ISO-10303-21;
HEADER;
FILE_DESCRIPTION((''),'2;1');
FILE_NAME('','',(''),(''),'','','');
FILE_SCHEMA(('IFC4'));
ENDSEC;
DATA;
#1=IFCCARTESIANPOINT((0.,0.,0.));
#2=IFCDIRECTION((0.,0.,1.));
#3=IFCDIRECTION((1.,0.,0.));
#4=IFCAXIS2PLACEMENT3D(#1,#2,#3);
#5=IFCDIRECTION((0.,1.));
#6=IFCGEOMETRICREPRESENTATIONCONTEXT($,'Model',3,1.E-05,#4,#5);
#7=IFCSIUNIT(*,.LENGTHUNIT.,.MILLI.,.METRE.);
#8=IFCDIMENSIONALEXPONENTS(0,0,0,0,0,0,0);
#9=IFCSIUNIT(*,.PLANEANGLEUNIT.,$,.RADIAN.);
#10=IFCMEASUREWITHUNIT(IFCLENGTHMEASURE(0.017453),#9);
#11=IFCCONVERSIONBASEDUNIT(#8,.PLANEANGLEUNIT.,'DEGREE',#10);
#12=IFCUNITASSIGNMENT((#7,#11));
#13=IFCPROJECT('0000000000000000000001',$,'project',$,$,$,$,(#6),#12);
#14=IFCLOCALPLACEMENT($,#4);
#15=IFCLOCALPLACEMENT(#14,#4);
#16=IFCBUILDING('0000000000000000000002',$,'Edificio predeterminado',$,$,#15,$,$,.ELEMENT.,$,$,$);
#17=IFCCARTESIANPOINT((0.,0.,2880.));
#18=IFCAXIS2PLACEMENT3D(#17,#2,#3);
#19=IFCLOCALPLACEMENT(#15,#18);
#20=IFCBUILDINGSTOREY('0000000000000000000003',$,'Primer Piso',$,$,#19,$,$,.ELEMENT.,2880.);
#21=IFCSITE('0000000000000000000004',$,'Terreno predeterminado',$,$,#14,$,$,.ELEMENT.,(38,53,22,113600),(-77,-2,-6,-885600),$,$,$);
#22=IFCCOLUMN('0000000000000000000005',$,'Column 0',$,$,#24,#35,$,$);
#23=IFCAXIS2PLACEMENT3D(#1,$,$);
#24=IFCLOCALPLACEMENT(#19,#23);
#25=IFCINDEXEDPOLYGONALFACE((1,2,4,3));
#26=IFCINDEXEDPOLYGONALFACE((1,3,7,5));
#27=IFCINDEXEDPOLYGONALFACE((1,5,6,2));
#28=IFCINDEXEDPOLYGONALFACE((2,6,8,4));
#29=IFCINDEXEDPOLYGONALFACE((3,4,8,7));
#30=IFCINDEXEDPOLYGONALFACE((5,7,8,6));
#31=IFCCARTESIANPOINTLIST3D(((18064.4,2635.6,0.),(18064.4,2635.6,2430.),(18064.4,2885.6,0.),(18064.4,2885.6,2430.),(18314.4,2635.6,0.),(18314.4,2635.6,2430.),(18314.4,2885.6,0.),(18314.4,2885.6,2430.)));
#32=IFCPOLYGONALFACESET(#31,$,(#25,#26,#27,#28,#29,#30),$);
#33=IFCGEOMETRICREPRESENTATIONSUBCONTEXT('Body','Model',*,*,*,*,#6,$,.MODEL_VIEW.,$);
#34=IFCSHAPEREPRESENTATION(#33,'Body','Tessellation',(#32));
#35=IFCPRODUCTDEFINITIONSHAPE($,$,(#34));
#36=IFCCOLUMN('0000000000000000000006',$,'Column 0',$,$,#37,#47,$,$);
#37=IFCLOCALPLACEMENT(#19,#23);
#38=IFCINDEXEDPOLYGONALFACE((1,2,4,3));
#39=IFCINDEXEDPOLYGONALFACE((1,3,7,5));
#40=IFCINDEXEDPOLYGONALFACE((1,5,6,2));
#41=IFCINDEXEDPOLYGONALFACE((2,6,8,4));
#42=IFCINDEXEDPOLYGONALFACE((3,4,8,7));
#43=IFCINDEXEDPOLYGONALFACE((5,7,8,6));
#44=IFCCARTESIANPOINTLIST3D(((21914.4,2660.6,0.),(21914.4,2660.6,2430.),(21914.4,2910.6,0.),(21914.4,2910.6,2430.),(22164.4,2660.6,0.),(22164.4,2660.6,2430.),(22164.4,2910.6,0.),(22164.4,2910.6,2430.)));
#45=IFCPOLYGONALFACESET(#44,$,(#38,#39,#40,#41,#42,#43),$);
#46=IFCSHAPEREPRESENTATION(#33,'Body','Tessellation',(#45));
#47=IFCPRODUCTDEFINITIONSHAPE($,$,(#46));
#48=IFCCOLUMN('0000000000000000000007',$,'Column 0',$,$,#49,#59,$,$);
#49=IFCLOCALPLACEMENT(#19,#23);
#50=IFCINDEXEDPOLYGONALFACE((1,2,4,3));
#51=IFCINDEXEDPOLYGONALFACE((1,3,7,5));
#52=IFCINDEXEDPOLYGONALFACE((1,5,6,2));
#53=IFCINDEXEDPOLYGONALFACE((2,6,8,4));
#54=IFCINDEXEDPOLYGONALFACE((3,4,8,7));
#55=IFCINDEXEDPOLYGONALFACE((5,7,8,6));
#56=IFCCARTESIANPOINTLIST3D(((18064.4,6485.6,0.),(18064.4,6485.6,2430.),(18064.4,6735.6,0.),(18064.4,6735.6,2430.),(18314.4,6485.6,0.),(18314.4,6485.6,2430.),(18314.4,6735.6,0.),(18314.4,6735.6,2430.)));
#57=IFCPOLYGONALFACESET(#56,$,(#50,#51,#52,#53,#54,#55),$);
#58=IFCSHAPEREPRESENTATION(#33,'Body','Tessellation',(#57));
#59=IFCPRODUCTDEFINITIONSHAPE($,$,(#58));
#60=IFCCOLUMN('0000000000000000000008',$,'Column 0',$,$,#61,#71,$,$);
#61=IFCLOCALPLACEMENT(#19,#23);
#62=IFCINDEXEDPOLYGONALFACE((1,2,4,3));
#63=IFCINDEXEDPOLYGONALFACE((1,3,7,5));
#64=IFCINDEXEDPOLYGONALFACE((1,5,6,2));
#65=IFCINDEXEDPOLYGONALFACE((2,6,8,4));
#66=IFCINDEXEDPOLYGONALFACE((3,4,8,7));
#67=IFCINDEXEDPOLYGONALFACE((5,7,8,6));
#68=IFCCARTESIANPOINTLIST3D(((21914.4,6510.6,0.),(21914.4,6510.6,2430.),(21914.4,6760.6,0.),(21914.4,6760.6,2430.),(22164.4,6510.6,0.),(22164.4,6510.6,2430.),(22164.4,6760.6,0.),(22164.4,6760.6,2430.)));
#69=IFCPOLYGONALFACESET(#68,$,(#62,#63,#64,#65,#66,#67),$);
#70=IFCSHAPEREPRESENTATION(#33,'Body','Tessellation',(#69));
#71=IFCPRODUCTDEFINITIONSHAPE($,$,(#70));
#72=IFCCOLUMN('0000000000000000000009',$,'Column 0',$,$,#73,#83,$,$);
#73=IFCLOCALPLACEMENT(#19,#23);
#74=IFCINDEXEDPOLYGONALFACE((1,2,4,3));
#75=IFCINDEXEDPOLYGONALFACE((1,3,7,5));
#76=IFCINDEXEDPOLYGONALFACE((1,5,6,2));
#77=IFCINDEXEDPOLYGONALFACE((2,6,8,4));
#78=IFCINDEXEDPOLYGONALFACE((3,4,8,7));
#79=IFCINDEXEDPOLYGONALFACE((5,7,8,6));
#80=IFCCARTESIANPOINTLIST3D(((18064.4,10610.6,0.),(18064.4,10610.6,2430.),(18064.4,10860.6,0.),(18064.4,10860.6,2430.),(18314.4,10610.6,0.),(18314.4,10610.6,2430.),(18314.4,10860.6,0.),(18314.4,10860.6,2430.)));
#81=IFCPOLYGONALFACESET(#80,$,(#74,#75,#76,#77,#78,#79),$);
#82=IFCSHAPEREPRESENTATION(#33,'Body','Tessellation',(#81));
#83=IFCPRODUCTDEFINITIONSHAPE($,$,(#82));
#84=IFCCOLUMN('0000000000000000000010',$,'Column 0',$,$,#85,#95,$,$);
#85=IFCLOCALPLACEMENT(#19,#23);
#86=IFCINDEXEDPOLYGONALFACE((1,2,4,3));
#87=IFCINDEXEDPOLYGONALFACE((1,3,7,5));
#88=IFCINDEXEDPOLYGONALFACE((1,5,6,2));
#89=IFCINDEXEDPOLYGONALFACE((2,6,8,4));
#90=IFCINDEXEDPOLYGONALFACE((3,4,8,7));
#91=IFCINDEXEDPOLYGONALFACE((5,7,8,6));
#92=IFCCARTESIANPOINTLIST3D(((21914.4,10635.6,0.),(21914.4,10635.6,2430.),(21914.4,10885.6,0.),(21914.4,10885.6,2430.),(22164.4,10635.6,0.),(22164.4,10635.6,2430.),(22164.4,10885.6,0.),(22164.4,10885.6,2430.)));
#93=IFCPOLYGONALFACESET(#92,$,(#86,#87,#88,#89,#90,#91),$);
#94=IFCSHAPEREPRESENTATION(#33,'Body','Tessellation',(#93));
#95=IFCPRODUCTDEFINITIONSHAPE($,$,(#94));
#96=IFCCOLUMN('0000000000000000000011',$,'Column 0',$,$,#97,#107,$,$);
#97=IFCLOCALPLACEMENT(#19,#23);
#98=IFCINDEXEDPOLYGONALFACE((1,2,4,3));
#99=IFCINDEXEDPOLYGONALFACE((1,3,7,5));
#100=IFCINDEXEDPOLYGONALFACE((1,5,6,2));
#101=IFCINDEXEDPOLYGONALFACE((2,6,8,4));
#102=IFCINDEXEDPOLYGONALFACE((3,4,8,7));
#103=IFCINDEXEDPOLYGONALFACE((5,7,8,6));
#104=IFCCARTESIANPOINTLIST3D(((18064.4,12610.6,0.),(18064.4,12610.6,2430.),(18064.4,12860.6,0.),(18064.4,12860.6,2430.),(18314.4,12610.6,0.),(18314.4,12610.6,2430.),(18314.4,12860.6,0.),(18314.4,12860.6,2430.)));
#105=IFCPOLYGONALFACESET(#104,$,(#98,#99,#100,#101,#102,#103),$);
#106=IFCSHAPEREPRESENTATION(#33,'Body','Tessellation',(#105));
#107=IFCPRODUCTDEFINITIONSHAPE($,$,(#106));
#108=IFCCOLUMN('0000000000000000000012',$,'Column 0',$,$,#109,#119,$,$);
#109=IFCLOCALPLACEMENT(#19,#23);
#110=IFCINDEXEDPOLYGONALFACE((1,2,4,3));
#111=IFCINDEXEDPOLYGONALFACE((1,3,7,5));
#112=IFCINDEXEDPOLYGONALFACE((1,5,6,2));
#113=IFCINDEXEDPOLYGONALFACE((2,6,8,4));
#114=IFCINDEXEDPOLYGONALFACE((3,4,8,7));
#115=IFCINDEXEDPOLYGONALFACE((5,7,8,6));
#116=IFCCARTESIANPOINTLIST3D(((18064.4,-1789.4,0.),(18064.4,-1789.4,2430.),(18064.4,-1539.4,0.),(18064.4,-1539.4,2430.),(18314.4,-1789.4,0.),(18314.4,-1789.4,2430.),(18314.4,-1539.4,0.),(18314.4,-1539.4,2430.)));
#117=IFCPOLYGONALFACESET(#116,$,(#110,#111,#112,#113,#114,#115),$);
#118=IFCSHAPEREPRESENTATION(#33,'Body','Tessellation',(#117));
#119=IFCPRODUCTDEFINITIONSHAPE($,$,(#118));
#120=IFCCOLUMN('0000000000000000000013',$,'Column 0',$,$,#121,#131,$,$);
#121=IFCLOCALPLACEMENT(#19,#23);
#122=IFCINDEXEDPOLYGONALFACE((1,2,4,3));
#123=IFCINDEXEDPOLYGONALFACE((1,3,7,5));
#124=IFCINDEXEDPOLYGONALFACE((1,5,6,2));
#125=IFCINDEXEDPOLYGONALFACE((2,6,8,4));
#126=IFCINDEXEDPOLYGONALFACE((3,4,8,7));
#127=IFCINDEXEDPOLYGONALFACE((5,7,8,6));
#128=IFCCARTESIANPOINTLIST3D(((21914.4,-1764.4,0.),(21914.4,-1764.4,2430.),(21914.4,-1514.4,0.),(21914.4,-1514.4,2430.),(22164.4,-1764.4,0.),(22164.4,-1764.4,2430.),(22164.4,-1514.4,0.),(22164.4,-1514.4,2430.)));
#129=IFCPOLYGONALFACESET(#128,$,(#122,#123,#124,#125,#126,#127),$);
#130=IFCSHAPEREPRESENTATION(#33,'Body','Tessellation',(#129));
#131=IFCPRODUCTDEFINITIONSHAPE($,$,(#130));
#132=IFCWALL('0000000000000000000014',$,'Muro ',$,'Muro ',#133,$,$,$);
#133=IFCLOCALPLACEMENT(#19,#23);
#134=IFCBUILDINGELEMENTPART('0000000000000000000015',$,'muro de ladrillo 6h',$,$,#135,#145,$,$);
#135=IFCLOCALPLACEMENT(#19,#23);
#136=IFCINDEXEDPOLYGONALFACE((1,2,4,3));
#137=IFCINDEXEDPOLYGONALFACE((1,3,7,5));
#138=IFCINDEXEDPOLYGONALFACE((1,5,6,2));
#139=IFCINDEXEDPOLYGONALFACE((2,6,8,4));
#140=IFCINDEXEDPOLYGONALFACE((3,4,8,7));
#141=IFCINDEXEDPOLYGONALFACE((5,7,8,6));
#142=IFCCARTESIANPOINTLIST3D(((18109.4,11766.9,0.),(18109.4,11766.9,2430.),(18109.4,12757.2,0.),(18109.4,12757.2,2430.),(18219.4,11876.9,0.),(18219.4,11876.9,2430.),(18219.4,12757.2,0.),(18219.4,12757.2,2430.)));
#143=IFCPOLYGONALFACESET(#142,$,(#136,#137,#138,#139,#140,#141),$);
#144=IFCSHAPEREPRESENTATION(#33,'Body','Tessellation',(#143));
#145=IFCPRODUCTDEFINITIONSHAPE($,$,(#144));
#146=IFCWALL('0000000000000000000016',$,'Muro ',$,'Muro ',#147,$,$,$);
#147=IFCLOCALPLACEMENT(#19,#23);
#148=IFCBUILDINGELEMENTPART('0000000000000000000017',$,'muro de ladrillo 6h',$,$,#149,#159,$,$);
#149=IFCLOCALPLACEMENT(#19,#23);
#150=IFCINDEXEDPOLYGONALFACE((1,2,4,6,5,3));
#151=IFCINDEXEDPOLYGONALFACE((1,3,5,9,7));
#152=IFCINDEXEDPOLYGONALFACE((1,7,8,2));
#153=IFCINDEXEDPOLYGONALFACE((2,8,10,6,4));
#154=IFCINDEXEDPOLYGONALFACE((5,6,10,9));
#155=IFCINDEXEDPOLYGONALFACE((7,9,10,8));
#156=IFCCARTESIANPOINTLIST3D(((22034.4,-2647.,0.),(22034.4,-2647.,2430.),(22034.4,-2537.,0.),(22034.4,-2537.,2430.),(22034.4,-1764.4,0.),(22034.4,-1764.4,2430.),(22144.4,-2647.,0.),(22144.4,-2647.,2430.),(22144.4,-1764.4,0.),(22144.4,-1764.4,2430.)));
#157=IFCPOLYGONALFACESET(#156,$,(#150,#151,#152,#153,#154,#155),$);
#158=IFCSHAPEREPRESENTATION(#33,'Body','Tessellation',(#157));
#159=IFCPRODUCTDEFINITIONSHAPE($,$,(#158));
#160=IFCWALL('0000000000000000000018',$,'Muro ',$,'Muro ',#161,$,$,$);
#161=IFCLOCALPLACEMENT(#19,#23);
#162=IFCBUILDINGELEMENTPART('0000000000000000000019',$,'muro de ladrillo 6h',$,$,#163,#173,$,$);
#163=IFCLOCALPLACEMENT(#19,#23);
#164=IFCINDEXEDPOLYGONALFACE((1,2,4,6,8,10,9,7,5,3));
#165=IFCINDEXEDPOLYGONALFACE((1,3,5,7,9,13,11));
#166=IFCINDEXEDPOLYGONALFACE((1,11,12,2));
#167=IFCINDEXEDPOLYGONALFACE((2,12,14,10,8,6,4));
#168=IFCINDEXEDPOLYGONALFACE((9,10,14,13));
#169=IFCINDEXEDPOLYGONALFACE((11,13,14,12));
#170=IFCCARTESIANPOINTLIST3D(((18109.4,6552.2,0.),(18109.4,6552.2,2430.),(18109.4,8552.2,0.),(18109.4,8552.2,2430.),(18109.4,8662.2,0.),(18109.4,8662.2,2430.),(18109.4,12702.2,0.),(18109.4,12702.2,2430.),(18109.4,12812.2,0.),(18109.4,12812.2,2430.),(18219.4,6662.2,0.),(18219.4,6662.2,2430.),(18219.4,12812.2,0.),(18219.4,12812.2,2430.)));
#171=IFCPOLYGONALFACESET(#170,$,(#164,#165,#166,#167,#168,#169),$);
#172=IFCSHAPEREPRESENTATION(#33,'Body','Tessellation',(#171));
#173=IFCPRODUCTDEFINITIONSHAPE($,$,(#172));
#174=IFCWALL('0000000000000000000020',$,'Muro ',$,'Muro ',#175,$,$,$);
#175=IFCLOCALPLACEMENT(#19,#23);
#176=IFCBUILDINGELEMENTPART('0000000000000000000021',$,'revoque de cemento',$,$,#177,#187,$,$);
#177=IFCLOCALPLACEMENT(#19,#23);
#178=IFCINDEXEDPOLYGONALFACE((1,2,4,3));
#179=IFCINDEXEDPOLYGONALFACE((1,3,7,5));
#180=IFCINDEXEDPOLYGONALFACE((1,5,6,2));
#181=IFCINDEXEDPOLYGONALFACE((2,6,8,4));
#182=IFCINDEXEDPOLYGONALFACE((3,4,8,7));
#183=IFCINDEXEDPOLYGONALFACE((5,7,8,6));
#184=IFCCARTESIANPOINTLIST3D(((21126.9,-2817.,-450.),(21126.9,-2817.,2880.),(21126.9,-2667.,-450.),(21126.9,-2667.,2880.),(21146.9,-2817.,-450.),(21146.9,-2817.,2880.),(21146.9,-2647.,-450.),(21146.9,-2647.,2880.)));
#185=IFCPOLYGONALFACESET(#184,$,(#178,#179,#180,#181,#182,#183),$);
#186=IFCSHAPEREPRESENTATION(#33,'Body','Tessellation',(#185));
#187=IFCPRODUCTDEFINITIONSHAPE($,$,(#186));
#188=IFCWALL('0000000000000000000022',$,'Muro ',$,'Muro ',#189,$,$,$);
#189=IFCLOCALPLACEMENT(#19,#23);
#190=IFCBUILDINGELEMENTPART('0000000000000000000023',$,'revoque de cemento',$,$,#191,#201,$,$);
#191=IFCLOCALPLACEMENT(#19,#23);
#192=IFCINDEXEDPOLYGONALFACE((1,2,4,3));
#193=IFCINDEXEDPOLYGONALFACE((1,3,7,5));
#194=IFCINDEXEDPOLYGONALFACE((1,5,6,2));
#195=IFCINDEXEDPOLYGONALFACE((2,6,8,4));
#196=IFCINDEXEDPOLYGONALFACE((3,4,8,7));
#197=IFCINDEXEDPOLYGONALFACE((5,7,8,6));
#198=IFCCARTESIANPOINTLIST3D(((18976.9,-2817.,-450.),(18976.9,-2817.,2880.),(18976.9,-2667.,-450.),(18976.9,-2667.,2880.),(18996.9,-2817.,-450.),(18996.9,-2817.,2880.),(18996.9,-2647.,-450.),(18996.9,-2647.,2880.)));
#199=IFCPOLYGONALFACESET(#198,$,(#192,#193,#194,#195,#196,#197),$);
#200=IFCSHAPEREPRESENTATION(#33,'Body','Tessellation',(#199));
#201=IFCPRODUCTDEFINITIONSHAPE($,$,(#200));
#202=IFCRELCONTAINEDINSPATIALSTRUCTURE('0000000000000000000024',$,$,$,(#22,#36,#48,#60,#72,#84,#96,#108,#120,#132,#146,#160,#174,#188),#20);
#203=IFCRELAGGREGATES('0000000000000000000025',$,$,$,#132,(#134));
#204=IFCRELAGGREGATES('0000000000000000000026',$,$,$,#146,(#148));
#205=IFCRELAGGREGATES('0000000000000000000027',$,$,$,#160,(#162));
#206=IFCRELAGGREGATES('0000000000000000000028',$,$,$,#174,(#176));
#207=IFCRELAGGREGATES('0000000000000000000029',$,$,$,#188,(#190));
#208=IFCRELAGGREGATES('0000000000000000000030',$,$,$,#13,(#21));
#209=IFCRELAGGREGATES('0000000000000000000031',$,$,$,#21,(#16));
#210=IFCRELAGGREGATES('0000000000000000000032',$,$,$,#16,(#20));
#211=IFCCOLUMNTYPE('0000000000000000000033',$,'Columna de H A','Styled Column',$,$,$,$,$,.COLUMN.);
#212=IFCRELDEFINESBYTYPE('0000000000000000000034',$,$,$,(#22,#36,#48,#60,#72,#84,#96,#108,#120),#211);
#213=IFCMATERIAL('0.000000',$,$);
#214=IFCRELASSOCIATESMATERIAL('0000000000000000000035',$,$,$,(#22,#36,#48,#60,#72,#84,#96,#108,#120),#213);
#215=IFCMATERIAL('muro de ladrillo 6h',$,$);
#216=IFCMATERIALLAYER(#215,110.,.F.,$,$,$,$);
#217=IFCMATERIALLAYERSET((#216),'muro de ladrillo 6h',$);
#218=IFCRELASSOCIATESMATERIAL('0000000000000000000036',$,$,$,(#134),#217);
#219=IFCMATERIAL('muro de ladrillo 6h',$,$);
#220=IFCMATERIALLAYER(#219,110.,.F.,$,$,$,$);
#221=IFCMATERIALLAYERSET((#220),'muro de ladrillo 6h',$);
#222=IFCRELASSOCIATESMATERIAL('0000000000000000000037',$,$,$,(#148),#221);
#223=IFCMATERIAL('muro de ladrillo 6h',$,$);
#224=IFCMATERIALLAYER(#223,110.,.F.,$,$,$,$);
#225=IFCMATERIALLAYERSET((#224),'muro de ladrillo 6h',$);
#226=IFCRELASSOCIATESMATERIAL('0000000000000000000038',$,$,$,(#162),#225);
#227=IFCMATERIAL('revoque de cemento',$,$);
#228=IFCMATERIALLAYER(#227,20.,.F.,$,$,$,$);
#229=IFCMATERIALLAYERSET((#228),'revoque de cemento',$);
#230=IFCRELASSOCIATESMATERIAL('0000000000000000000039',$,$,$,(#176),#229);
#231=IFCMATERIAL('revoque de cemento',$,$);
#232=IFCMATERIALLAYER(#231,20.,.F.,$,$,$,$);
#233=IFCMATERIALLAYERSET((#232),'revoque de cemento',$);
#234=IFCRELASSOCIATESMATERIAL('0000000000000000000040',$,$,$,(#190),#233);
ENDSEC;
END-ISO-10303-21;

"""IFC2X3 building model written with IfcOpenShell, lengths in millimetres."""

from ifc_helpers import new_model, entity, si_unit, converted_unit, direction, frame, origin_with_axes, place, context, subcontext, project, spatial, polyline, outline, extrude, clip, bounded_halfspace, material, layer, layer_set, layer_usage, type_object, element, aggregate, save


model = new_model("IFC2X3")

# Units and contexts
model_context = context("Model", 3, precision=1e-05, world=origin_with_axes(), true_north=direction((0.0, 1.0)))
body_context = subcontext(model_context, "Body", "Model", "MODEL_VIEW")
ifc_project = project(units=[si_unit("LENGTHUNIT", "METRE", prefix="MILLI"), converted_unit("PLANEANGLEUNIT", "DEGREE", entity("IfcLengthMeasure", 0.017453), si_unit("PLANEANGLEUNIT", "RADIAN"), dimensions=[0, 0, 0, 0, 0, 0, 0])], contexts=[model_context])

# Site, building, storey
site_placement = place(None, origin_with_axes())
site = spatial("IfcSite", under=ifc_project, at=site_placement, Name="Terreno predeterminado", CompositionType="ELEMENT", RefLatitude=(38, 53, 22, 113600), RefLongitude=(-77, -2, -6, -885600))
building_placement = place(site_placement, origin_with_axes())
building = spatial("IfcBuilding", under=site, at=building_placement, Name="Edificio predeterminado", CompositionType="ELEMENT")
storey_placement = place(building_placement, frame((0.0, 0.0, 2880.0), z_axis=(0.0, 0.0, 1.0), x_axis=(1.0, 0.0, 0.0)))
storey = spatial("IfcBuildingStorey", under=building, at=storey_placement, Name="Primer Piso", CompositionType="ELEMENT", Elevation=2880.0)

# Columns
ifc_material_1 = material(Name="0.000000")
column_type = type_object("IfcColumnType", Name="Columna de H A", Description="Styled Column", PredefinedType="COLUMN")
for number, where, z_axis, x_axis, name in (
    (1, (18189.4, 2760.6, 0.0), (0.0, 0.0, 1.0), (1.0, 0.0, 0.0), "Column 0"),
    (2, (22039.4, 2785.6, 0.0), (0.0, 0.0, 1.0), (1.0, 0.0, 0.0), "Column 0"),
    (3, (18189.4, 6610.6, 0.0), (0.0, 0.0, 1.0), (1.0, 0.0, 0.0), "Column 0"),
    (4, (22039.4, 6635.6, 0.0), (0.0, 0.0, 1.0), (1.0, 0.0, 0.0), "Column 0"),
    (5, (18189.4, 10735.6, 0.0), (0.0, 0.0, 1.0), (1.0, 0.0, 0.0), "Column 0"),
    (6, (22039.4, 10760.6, 0.0), (0.0, 0.0, 1.0), (1.0, 0.0, 0.0), "Column 0"),
    (7, (18189.4, 12735.6, 0.0), (0.0, 0.0, 1.0), (1.0, 0.0, 0.0), "Column 0"),
    (8, (18189.4, -1664.4, 0.0), (0.0, 0.0, 1.0), (1.0, 0.0, 0.0), "Column 0"),
    (9, (22039.4, -1639.4, 0.0), (0.0, 0.0, 1.0), (1.0, 0.0, 0.0), "Column 0"),
):
    element("IfcColumn", number, at=place(storey_placement, frame(where, z_axis=z_axis, x_axis=x_axis)), inside=storey, type_object=column_type, material=ifc_material_1, Name=name, context=body_context, shape_type="SweptSolid", body=[
        extrude(outline(polyline([(-125.0, -125.0), (125.0, -125.0), (125.0, 125.0), (-125.0, 125.0), (-125.0, -125.0)])), origin_with_axes(), (0.0, 0.0, 1.0), 2430.0),
    ])

# Walls, building element parts
wall_1_placement = place(storey_placement, frame((18164.4, 11821.9, 0.0), z_axis=(0.0, 0.0, 1.0), x_axis=(0.0, 1.0, 0.0)))
wall_1 = element("IfcWall", 10, at=wall_1_placement, inside=storey, Name="Muro ", ObjectType="Muro ")
ifc_material_2 = material(Name="muro de ladrillo 6h")
ifc_layer_1 = layer(ifc_material_2, 110.0, ventilated=False)
ifc_layer_set_1 = layer_set([ifc_layer_1], Name="muro de ladrillo 6h")
ifc_layer_usage_1 = layer_usage(ifc_layer_set_1, "AXIS2", "NEGATIVE", -55.0)
building_element_part_1_placement = place(wall_1_placement, origin_with_axes())
building_element_part_1 = element("IfcBuildingElementPart", 11, at=building_element_part_1_placement, material=ifc_layer_usage_1, Name="muro de ladrillo 6h", context=body_context, shape_type="SweptSolid", body=[
    extrude(outline(polyline([(935.2, 55.0), (935.2, -55.0), (55.0, -55.0), (-55.0, 55.0), (935.2, 55.0)])), origin_with_axes(), (0.0, 0.0, 1.0), 2430.0),
])
aggregate(wall_1, [building_element_part_1])
wall_2_placement = place(storey_placement, frame((22089.4, -1764.4, 0.0), z_axis=(0.0, 0.0, 1.0), x_axis=(0.0, -1.0, 0.0)))
wall_2 = element("IfcWall", 12, at=wall_2_placement, inside=storey, Name="Muro ", ObjectType="Muro ")
ifc_material_3 = material(Name="muro de ladrillo 6h")
ifc_layer_2 = layer(ifc_material_3, 110.0, ventilated=False)
ifc_layer_set_2 = layer_set([ifc_layer_2], Name="muro de ladrillo 6h")
ifc_layer_usage_2 = layer_usage(ifc_layer_set_2, "AXIS2", "NEGATIVE", -55.0)
building_element_part_2_placement = place(wall_2_placement, origin_with_axes())
building_element_part_2 = element("IfcBuildingElementPart", 13, at=building_element_part_2_placement, material=ifc_layer_usage_2, Name="muro de ladrillo 6h", context=body_context, shape_type="SweptSolid", body=[
    extrude(outline(polyline([(882.6, 55.0), (882.6, -55.0), (772.6, -55.0), (0.0, -55.0), (0.0, 55.0), (882.6, 55.0)])), origin_with_axes(), (0.0, 0.0, 1.0), 2430.0),
])
aggregate(wall_2, [building_element_part_2])
wall_3_placement = place(storey_placement, frame((18164.4, 12757.2, 0.0), z_axis=(0.0, 0.0, 1.0), x_axis=(0.0, -1.0, 0.0)))
wall_3 = element("IfcWall", 14, at=wall_3_placement, inside=storey, Name="Muro ", ObjectType="Muro ")
ifc_material_4 = material(Name="muro de ladrillo 6h")
ifc_layer_3 = layer(ifc_material_4, 110.0, ventilated=False)
ifc_layer_set_3 = layer_set([ifc_layer_3], Name="muro de ladrillo 6h")
ifc_layer_usage_3 = layer_usage(ifc_layer_set_3, "AXIS2", "NEGATIVE", -55.0)
building_element_part_3_placement = place(wall_3_placement, origin_with_axes())
building_element_part_3 = element("IfcBuildingElementPart", 15, at=building_element_part_3_placement, material=ifc_layer_usage_3, Name="muro de ladrillo 6h", context=body_context, shape_type="SweptSolid", body=[
    extrude(outline(polyline([(6095.0, 55.0), (6205.0, -55.0), (4205.0, -55.0), (4095.0, -55.0), (55.0, -55.0), (-55.0, -55.0), (-55.0, 55.0), (6095.0, 55.0)])), origin_with_axes(), (0.0, 0.0, 1.0), 2430.0),
])
aggregate(wall_3, [building_element_part_3])
wall_4_placement = place(storey_placement, frame((21201.9, -2817.0, 0.0), z_axis=(0.0, 0.0, 1.0), x_axis=(0.0, 1.0, 0.0)))
wall_4 = element("IfcWall", 16, at=wall_4_placement, inside=storey, Name="Muro ", ObjectType="Muro ")
ifc_material_5 = material(Name="revoque de cemento")
ifc_layer_4 = layer(ifc_material_5, 20.0, ventilated=False)
ifc_layer_set_4 = layer_set([ifc_layer_4], Name="revoque de cemento")
ifc_layer_usage_4 = layer_usage(ifc_layer_set_4, "AXIS2", "NEGATIVE", -75.0)
building_element_part_4_placement = place(wall_4_placement, origin_with_axes())
building_element_part_4 = element("IfcBuildingElementPart", 17, at=building_element_part_4_placement, material=ifc_layer_usage_4, Name="revoque de cemento", context=body_context, shape_type="Clipping", body=[
    clip(clip(extrude(outline(polyline([(150.0, 75.0), (170.0, 55.0), (0.0, 55.0), (0.0, 75.0), (150.0, 75.0)])), frame((0.0, 0.0, -450.0), z_axis=(0.0, 0.0, 1.0), x_axis=(1.0, 0.0, 0.0)), (0.0, 0.0, 1.0), 3330.0), bounded_halfspace(frame((0.0, 0.0, -450.0), z_axis=(0.0, 0.0, 1.0), x_axis=(1.0, 0.0, 0.0)), True, origin_with_axes(), polyline([(-150.0, -150.0), (375.0, -150.0), (375.0, 150.0), (-150.0, 150.0), (-150.0, -150.0)]))), bounded_halfspace(frame((0.0, 0.0, 2880.0), z_axis=(0.0, 0.0, 1.0), x_axis=(1.0, 0.0, 0.0)), False, origin_with_axes(), polyline([(-150.0, -150.0), (375.0, -150.0), (375.0, 150.0), (-150.0, 150.0), (-150.0, -150.0)]))),
])
aggregate(wall_4, [building_element_part_4])
wall_5_placement = place(storey_placement, frame((19051.9, -2817.0, 0.0), z_axis=(0.0, 0.0, 1.0), x_axis=(0.0, 1.0, 0.0)))
wall_5 = element("IfcWall", 18, at=wall_5_placement, inside=storey, Name="Muro ", ObjectType="Muro ")
ifc_material_6 = material(Name="revoque de cemento")
ifc_layer_5 = layer(ifc_material_6, 20.0, ventilated=False)
ifc_layer_set_5 = layer_set([ifc_layer_5], Name="revoque de cemento")
ifc_layer_usage_5 = layer_usage(ifc_layer_set_5, "AXIS2", "NEGATIVE", -75.0)
building_element_part_5_placement = place(wall_5_placement, origin_with_axes())
building_element_part_5 = element("IfcBuildingElementPart", 19, at=building_element_part_5_placement, material=ifc_layer_usage_5, Name="revoque de cemento", context=body_context, shape_type="Clipping", body=[
    clip(clip(extrude(outline(polyline([(150.0, 75.0), (170.0, 55.0), (0.0, 55.0), (0.0, 75.0), (150.0, 75.0)])), frame((0.0, 0.0, -450.0), z_axis=(0.0, 0.0, 1.0), x_axis=(1.0, 0.0, 0.0)), (0.0, 0.0, 1.0), 3330.0), bounded_halfspace(frame((0.0, 0.0, -450.0), z_axis=(0.0, 0.0, 1.0), x_axis=(1.0, 0.0, 0.0)), True, origin_with_axes(), polyline([(-150.0, -150.0), (375.0, -150.0), (375.0, 150.0), (-150.0, 150.0), (-150.0, -150.0)]))), bounded_halfspace(frame((0.0, 0.0, 2880.0), z_axis=(0.0, 0.0, 1.0), x_axis=(1.0, 0.0, 0.0)), False, origin_with_axes(), polyline([(-150.0, -150.0), (375.0, -150.0), (375.0, 150.0), (-150.0, 150.0), (-150.0, -150.0)]))),
])
aggregate(wall_5, [building_element_part_5])

save(model, "model.ifc")
